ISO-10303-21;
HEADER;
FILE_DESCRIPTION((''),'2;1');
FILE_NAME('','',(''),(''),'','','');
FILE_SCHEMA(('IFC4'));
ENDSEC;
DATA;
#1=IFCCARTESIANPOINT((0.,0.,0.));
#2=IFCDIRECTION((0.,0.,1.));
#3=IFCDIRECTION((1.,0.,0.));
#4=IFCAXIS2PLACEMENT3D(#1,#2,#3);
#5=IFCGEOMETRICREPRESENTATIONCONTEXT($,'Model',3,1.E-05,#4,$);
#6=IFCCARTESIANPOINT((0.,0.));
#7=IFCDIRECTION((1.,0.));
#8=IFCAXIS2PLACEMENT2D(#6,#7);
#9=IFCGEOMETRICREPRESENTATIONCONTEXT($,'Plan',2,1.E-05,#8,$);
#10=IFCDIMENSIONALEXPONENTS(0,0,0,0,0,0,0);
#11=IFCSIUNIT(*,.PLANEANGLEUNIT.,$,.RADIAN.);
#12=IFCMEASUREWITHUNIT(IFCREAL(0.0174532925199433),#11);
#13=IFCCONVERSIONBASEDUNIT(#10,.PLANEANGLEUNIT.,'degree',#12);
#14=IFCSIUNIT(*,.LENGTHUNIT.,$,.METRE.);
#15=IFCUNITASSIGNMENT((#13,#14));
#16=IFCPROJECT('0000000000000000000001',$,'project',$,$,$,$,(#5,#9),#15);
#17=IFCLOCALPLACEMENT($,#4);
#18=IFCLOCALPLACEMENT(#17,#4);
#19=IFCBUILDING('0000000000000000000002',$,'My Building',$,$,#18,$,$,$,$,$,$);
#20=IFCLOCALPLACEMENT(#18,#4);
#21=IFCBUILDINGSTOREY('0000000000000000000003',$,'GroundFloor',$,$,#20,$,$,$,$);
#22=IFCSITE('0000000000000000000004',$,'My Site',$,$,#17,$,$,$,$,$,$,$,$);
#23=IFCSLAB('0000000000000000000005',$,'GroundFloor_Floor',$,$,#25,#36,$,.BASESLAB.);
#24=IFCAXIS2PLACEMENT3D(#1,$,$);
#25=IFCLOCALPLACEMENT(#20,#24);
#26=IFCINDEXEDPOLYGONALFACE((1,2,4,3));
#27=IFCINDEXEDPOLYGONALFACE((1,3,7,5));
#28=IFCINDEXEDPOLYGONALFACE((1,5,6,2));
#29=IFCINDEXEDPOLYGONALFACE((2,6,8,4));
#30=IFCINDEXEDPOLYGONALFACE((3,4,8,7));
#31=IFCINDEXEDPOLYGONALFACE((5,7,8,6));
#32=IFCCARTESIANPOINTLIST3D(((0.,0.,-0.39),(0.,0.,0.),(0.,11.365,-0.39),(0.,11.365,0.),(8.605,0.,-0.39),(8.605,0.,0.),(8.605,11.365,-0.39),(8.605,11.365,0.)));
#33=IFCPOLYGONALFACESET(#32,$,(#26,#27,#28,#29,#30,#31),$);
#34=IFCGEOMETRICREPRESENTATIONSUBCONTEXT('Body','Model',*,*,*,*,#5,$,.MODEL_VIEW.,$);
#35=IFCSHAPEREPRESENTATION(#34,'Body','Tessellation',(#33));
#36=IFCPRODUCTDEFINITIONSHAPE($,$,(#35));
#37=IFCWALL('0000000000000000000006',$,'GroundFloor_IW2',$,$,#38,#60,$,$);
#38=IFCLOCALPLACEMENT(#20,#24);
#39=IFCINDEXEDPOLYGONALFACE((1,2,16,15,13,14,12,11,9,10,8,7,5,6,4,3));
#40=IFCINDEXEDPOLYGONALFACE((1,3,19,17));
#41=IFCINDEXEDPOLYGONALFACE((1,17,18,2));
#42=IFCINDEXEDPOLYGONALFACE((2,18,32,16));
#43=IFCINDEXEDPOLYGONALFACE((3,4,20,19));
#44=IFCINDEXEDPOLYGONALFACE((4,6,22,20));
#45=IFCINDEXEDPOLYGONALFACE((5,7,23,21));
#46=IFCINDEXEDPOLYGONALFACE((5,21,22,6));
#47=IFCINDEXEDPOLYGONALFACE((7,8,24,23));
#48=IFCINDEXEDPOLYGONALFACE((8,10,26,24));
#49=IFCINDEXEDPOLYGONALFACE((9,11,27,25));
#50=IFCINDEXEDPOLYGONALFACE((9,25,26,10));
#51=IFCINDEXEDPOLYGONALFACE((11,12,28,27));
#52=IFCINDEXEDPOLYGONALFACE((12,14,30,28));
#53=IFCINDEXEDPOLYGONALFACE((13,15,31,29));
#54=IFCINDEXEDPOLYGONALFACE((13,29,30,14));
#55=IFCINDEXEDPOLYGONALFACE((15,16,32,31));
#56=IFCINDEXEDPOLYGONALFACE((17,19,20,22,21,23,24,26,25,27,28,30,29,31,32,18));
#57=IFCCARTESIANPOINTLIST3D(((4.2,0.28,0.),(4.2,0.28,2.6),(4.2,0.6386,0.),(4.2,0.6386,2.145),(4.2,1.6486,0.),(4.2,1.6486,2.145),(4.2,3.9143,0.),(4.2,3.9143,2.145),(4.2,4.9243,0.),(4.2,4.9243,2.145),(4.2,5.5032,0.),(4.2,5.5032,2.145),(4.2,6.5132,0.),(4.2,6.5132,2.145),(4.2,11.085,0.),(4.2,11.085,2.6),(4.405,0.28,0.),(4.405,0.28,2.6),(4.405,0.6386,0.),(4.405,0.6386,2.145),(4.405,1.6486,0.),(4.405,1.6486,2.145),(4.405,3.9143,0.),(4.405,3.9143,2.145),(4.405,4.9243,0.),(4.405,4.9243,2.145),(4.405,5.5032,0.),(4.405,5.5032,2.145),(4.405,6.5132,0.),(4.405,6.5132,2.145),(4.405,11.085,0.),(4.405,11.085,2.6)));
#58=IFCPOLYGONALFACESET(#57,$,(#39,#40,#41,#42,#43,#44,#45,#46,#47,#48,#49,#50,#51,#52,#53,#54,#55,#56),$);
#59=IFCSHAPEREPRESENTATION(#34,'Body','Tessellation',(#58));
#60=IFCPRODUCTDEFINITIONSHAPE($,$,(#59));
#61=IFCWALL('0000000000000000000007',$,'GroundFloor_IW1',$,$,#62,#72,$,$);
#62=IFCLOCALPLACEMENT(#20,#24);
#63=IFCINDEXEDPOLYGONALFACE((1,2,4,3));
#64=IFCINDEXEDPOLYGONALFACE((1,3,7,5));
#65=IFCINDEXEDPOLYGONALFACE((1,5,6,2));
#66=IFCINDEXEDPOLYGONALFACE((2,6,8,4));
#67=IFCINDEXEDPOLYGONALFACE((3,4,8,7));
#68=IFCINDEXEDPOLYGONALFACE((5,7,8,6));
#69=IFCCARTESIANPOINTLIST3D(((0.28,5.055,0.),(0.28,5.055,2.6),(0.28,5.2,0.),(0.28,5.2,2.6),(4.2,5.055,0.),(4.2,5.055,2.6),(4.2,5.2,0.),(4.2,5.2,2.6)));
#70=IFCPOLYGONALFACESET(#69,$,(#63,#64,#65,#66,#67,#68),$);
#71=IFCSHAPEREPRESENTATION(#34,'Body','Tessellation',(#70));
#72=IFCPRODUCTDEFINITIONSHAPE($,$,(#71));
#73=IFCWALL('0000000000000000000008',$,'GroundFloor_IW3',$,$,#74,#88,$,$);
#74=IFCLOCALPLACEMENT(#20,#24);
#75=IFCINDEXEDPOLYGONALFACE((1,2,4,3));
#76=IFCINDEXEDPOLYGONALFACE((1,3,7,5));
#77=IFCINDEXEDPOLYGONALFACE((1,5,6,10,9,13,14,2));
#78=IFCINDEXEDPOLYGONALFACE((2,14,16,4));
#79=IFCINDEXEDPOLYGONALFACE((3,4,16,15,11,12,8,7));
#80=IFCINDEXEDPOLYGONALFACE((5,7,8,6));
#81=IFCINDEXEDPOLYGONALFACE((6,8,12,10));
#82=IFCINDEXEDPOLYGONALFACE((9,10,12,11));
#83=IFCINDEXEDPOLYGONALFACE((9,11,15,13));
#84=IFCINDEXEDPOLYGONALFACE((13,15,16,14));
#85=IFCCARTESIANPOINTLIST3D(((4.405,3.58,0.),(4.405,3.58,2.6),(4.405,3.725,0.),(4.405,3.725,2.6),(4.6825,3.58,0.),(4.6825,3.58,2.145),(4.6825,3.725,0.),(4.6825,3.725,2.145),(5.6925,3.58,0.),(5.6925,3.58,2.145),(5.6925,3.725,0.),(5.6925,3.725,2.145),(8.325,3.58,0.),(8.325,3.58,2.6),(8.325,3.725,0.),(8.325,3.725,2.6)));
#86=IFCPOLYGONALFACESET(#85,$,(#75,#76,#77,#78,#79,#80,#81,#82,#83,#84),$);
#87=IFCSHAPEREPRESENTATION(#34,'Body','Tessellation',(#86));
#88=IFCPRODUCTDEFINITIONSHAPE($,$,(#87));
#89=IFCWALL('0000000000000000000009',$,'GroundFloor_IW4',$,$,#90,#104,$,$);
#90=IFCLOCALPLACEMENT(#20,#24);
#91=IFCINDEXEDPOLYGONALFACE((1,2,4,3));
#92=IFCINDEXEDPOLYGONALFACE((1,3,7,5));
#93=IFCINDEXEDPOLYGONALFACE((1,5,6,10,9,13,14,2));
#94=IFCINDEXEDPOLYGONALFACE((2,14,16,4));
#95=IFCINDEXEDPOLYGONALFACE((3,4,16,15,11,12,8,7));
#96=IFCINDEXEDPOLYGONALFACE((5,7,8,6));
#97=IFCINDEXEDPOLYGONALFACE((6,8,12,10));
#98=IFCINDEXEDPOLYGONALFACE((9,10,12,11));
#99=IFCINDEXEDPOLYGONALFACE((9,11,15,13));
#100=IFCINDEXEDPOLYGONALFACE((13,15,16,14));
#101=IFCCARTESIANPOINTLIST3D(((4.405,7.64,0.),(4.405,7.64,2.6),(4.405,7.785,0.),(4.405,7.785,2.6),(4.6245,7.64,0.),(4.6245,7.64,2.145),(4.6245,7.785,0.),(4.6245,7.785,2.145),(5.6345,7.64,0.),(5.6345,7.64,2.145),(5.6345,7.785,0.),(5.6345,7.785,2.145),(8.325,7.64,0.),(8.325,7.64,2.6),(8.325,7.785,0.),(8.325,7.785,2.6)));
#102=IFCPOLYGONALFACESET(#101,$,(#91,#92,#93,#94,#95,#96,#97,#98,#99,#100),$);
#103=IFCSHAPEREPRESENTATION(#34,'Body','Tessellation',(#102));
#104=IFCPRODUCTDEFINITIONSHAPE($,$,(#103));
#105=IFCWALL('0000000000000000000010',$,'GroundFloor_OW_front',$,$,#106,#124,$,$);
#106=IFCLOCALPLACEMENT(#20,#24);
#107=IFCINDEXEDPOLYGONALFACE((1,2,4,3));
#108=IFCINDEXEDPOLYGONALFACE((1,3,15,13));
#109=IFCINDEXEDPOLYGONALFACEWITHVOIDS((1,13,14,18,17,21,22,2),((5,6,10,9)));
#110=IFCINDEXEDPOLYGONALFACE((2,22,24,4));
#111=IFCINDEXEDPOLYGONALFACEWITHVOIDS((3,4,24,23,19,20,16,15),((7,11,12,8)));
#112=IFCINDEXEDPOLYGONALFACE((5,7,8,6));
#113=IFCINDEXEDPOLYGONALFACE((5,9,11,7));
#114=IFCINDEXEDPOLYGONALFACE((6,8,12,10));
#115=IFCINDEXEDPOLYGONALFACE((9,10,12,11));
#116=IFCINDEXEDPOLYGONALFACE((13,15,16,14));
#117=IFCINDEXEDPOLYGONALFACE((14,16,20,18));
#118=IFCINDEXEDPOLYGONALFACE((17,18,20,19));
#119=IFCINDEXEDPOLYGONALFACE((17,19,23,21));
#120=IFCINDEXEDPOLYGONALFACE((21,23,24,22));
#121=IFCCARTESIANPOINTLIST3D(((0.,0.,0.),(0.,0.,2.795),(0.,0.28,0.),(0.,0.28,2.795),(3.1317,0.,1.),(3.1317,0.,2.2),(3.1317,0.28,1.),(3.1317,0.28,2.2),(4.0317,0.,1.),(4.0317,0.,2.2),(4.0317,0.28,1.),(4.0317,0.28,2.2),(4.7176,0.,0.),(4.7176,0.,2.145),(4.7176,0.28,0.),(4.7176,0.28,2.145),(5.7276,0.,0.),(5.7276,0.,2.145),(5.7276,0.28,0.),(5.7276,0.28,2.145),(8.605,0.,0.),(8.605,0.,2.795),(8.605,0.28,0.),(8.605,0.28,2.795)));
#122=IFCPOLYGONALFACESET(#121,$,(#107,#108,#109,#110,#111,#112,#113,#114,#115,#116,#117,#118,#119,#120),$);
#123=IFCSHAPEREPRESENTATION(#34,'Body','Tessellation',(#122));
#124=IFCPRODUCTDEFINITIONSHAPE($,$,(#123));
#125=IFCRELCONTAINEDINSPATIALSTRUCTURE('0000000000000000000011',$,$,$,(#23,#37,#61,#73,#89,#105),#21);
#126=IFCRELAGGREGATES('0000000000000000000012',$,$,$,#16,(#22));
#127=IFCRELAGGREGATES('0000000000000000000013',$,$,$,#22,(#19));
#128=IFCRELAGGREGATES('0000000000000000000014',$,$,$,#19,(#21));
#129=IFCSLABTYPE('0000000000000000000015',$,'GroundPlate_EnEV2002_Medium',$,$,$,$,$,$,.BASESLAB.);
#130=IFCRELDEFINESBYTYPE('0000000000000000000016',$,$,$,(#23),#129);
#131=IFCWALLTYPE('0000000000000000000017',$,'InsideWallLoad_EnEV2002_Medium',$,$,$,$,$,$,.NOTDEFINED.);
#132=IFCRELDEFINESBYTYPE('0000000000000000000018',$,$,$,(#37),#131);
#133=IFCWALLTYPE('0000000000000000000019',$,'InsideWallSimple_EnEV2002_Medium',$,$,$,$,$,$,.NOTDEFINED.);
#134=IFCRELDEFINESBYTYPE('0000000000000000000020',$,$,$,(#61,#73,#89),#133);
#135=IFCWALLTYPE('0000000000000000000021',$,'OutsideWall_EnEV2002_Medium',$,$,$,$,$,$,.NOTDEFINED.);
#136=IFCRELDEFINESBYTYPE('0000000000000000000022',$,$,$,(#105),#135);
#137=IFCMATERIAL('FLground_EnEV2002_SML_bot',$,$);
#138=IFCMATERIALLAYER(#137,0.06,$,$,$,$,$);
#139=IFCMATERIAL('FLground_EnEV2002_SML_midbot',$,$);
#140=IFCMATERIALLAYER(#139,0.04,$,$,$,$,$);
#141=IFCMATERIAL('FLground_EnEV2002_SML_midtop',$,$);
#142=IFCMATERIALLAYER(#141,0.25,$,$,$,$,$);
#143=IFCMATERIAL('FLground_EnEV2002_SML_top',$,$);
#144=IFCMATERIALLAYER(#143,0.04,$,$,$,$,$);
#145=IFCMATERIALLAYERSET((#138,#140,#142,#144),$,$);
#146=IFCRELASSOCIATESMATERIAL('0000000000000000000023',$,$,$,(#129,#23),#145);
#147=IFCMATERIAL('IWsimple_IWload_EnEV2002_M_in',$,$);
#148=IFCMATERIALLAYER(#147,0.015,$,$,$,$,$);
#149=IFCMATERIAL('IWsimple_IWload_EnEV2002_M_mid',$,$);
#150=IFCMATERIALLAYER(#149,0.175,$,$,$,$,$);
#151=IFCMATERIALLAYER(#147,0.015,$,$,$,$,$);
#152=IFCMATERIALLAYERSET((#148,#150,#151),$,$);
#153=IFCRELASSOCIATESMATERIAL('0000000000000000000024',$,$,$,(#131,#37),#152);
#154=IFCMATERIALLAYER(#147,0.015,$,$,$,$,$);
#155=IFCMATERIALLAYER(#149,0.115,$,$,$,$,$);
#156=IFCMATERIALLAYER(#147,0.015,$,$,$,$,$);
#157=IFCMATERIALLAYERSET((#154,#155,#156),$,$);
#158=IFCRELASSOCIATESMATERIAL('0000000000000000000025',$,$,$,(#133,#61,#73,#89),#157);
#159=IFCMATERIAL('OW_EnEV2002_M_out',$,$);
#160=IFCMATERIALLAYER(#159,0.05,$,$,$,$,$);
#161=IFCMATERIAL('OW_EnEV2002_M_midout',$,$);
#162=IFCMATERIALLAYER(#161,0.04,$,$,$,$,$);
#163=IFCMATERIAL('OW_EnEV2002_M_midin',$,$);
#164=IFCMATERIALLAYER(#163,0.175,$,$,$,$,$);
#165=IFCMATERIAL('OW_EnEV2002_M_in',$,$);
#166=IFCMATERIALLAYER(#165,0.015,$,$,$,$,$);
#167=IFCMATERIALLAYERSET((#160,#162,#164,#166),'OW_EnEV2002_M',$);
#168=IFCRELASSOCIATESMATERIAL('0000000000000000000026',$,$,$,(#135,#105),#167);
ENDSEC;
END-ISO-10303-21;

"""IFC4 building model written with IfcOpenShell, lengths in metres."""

from ifc_helpers import new_model, entity, si_unit, converted_unit, frame, origin_with_axes, origin_2d_with_axis, place, context, subcontext, project, spatial, line, indexed_curve, outline, extrude, source, transform, mapped, material, layer, layer_set, layer_usage, type_object, element, save


model = new_model("IFC4")

# Units and contexts
model_context = context("Model", 3, precision=1e-05, world=origin_with_axes())
plan_context = context("Plan", 2, precision=1e-05, world=origin_2d_with_axis())
body_context = subcontext(model_context, "Body", "Model", "MODEL_VIEW")
ifc_project = project(units=[converted_unit("PLANEANGLEUNIT", "degree", entity("IfcReal", 0.0174532925199433), si_unit("PLANEANGLEUNIT", "RADIAN"), dimensions=[0, 0, 0, 0, 0, 0, 0]), si_unit("LENGTHUNIT", "METRE")], contexts=[model_context, plan_context])

# Site, building, storey
site_placement = place(None, origin_with_axes())
site = spatial("IfcSite", under=ifc_project, at=site_placement, Name="My Site")
building_placement = place(site_placement, origin_with_axes())
building = spatial("IfcBuilding", under=site, at=building_placement, Name="My Building")
storey_placement = place(building_placement, origin_with_axes())
storey = spatial("IfcBuildingStorey", under=building, at=storey_placement, Name="GroundFloor")

# Slab
ifc_material_1 = material(Name="FLground_EnEV2002_SML_bot")
ifc_layer_1 = layer(ifc_material_1, 0.06)
ifc_material_2 = material(Name="FLground_EnEV2002_SML_midbot")
ifc_layer_2 = layer(ifc_material_2, 0.04)
ifc_material_3 = material(Name="FLground_EnEV2002_SML_midtop")
ifc_layer_3 = layer(ifc_material_3, 0.25)
ifc_material_4 = material(Name="FLground_EnEV2002_SML_top")
ifc_layer_4 = layer(ifc_material_4, 0.04)
ifc_layer_set_1 = layer_set([ifc_layer_1, ifc_layer_2, ifc_layer_3, ifc_layer_4])
ifc_layer_usage_1 = layer_usage(ifc_layer_set_1, "AXIS3", "POSITIVE", 0.0)
slab_type = type_object("IfcSlabType", Name="GroundPlate_EnEV2002_Medium", PredefinedType="BASESLAB", material=ifc_layer_set_1)
slab_placement = place(storey_placement, frame((0.0, 0.0, -0.39), z_axis=(0.0, 0.0, 1.0), x_axis=(1.0, 0.0, 0.0)))
element("IfcSlab", 1, at=slab_placement, inside=storey, type_object=slab_type, material=ifc_layer_usage_1, Name="GroundFloor_Floor", PredefinedType="BASESLAB", context=body_context, shape_type="SweptSolid", body=[
    extrude(outline(indexed_curve([(0.0, 0.0), (8.605, 0.0), (8.605, 11.365), (0.0, 11.365)], segments=[line(4, 1), line(1, 2), line(2, 3), line(3, 4)], self_intersect=False)), None, (0.0, 0.0, 1.0), 0.39),
])

# Wall, openings
ifc_material_5 = material(Name="IWsimple_IWload_EnEV2002_M_in")
ifc_layer_5 = layer(ifc_material_5, 0.015)
ifc_material_6 = material(Name="IWsimple_IWload_EnEV2002_M_mid")
ifc_layer_6 = layer(ifc_material_6, 0.175)
ifc_layer_7 = layer(ifc_material_5, 0.015)
ifc_layer_set_2 = layer_set([ifc_layer_5, ifc_layer_6, ifc_layer_7])
ifc_layer_usage_2 = layer_usage(ifc_layer_set_2, "AXIS2", "POSITIVE", 0.0)
wall_type_1 = type_object("IfcWallType", Name="InsideWallLoad_EnEV2002_Medium", PredefinedType="NOTDEFINED", material=ifc_layer_set_2)
wall_1_placement = place(storey_placement, frame((4.405, 0.28, 0.0), z_axis=(0.0, 0.0, 1.0), x_axis=(0.0, 1.0, 0.0)))
wall_1 = element("IfcWall", 2, at=wall_1_placement, inside=storey, type_object=wall_type_1, material=ifc_layer_usage_2, Name="GroundFloor_IW2", context=body_context, shape_type="SweptSolid", body=[
    extrude(outline(indexed_curve([(0.0, 0.0), (0.0, 0.205), (10.805, 0.205), (10.805, 0.0), (0.0, 0.0)], self_intersect=False)), origin_with_axes(), (0.0, 0.0, 1.0), 2.6),
])
shared_shape_1 = source(origin_with_axes(), body_context, "Body", "SweptSolid", [
    extrude(outline(indexed_curve([(0.0, 0.0), (1.01, 0.0), (1.01, 2.145), (0.0, 2.145)], segments=[line(1, 2, 3, 4, 1)])), frame((0.0, -0.1, 0.0), z_axis=(0.0, -1.0, 0.0), x_axis=(1.0, 0.0, 0.0)), (0.0, 0.0, -1.0), 0.48),
])
opening_1_placement = place(wall_1_placement, frame((3.6343, 0.0, 0.0), z_axis=(0.0, 0.0, 1.0), x_axis=(1.0, 0.0, 0.0)))
element("IfcOpeningElement", 3, at=opening_1_placement, cuts=wall_1, PredefinedType="OPENING", context=body_context, shape_type="MappedRepresentation", body=[
    mapped(shared_shape_1, transform((0.0, 0.0, 0.0), x_axis=(1.0, 0.0, 0.0), y_axis=(0.0, 1.0, 0.0), z_axis=(0.0, 0.0, 1.0), scale=1.0)),
])
opening_2_placement = place(wall_1_placement, frame((5.2232, 0.0, 0.0), z_axis=(0.0, 0.0, 1.0), x_axis=(1.0, 0.0, 0.0)))
element("IfcOpeningElement", 4, at=opening_2_placement, cuts=wall_1, PredefinedType="OPENING", context=body_context, shape_type="MappedRepresentation", body=[
    mapped(shared_shape_1, transform((0.0, 0.0, 0.0), x_axis=(1.0, 0.0, 0.0), y_axis=(0.0, 1.0, 0.0), z_axis=(0.0, 0.0, 1.0), scale=1.0)),
])
opening_3_placement = place(wall_1_placement, frame((0.3586, 0.0, 0.0), z_axis=(0.0, 0.0, 1.0), x_axis=(1.0, 0.0, 0.0)))
element("IfcOpeningElement", 5, at=opening_3_placement, cuts=wall_1, PredefinedType="OPENING", context=body_context, shape_type="MappedRepresentation", body=[
    mapped(shared_shape_1, transform((0.0, 0.0, 0.0), x_axis=(1.0, 0.0, 0.0), y_axis=(0.0, 1.0, 0.0), z_axis=(0.0, 0.0, 1.0), scale=1.0)),
])

# Wall
ifc_layer_8 = layer(ifc_material_5, 0.015)
ifc_layer_9 = layer(ifc_material_6, 0.115)
ifc_layer_10 = layer(ifc_material_5, 0.015)
ifc_layer_set_3 = layer_set([ifc_layer_8, ifc_layer_9, ifc_layer_10])
ifc_layer_usage_3 = layer_usage(ifc_layer_set_3, "AXIS2", "POSITIVE", 0.0)
wall_type_2 = type_object("IfcWallType", Name="InsideWallSimple_EnEV2002_Medium", PredefinedType="NOTDEFINED", material=ifc_layer_set_3)
wall_2_placement = place(storey_placement, frame((0.28, 5.055, 0.0), z_axis=(0.0, 0.0, 1.0), x_axis=(1.0, 0.0, 0.0)))
element("IfcWall", 6, at=wall_2_placement, inside=storey, type_object=wall_type_2, material=ifc_layer_usage_3, Name="GroundFloor_IW1", context=body_context, shape_type="SweptSolid", body=[
    extrude(outline(indexed_curve([(0.0, 0.0), (0.0, 0.145), (3.92, 0.145), (3.92, 0.0), (0.0, 0.0)], self_intersect=False)), origin_with_axes(), (0.0, 0.0, 1.0), 2.6),
])

# Walls, openings
ifc_layer_usage_4 = layer_usage(ifc_layer_set_3, "AXIS2", "POSITIVE", 0.0)
wall_3_placement = place(storey_placement, frame((4.405, 3.58, 0.0), z_axis=(0.0, 0.0, 1.0), x_axis=(1.0, 0.0, 0.0)))
wall_3 = element("IfcWall", 7, at=wall_3_placement, inside=storey, type_object=wall_type_2, material=ifc_layer_usage_4, Name="GroundFloor_IW3", context=body_context, shape_type="SweptSolid", body=[
    extrude(outline(indexed_curve([(0.0, 0.0), (0.0, 0.145), (3.92, 0.145), (3.92, 0.0), (0.0, 0.0)], self_intersect=False)), origin_with_axes(), (0.0, 0.0, 1.0), 2.6),
])
opening_4_placement = place(wall_3_placement, frame((0.2775, 0.0, 0.0), z_axis=(0.0, 0.0, 1.0), x_axis=(1.0, 0.0, 0.0)))
element("IfcOpeningElement", 8, at=opening_4_placement, cuts=wall_3, PredefinedType="OPENING", context=body_context, shape_type="MappedRepresentation", body=[
    mapped(shared_shape_1, transform((0.0, 0.0, 0.0), x_axis=(1.0, 0.0, 0.0), y_axis=(0.0, 1.0, 0.0), z_axis=(0.0, 0.0, 1.0), scale=1.0)),
])
ifc_layer_usage_5 = layer_usage(ifc_layer_set_3, "AXIS2", "POSITIVE", 0.0)
wall_4_placement = place(storey_placement, frame((4.405, 7.64, 0.0), z_axis=(0.0, 0.0, 1.0), x_axis=(1.0, 0.0, 0.0)))
wall_4 = element("IfcWall", 9, at=wall_4_placement, inside=storey, type_object=wall_type_2, material=ifc_layer_usage_5, Name="GroundFloor_IW4", context=body_context, shape_type="SweptSolid", body=[
    extrude(outline(indexed_curve([(0.0, 0.0), (0.0, 0.145), (3.92, 0.145), (3.92, 0.0), (0.0, 0.0)], self_intersect=False)), origin_with_axes(), (0.0, 0.0, 1.0), 2.6),
])
opening_5_placement = place(wall_4_placement, frame((0.2195, 0.0, 0.0), z_axis=(0.0, 0.0, 1.0), x_axis=(1.0, 0.0, 0.0)))
element("IfcOpeningElement", 10, at=opening_5_placement, cuts=wall_4, PredefinedType="OPENING", context=body_context, shape_type="MappedRepresentation", body=[
    mapped(shared_shape_1, transform((0.0, 0.0, 0.0), x_axis=(1.0, 0.0, 0.0), y_axis=(0.0, 1.0, 0.0), z_axis=(0.0, 0.0, 1.0), scale=1.0)),
])

# Wall, openings
ifc_material_7 = material(Name="OW_EnEV2002_M_out")
ifc_layer_11 = layer(ifc_material_7, 0.05)
ifc_material_8 = material(Name="OW_EnEV2002_M_midout")
ifc_layer_12 = layer(ifc_material_8, 0.04)
ifc_material_9 = material(Name="OW_EnEV2002_M_midin")
ifc_layer_13 = layer(ifc_material_9, 0.175)
ifc_material_10 = material(Name="OW_EnEV2002_M_in")
ifc_layer_14 = layer(ifc_material_10, 0.015)
ifc_layer_set_4 = layer_set([ifc_layer_11, ifc_layer_12, ifc_layer_13, ifc_layer_14], Name="OW_EnEV2002_M")
ifc_layer_usage_6 = layer_usage(ifc_layer_set_4, "AXIS2", "POSITIVE", 0.0)
wall_type_3 = type_object("IfcWallType", Name="OutsideWall_EnEV2002_Medium", PredefinedType="NOTDEFINED", material=ifc_layer_set_4)
wall_5_placement = place(storey_placement, origin_with_axes())
wall_5 = element("IfcWall", 11, at=wall_5_placement, inside=storey, type_object=wall_type_3, material=ifc_layer_usage_6, Name="GroundFloor_OW_front", context=body_context, shape_type="SweptSolid", body=[
    extrude(outline(indexed_curve([(0.0, 0.0), (0.0, 0.28), (8.605, 0.28), (8.605, 0.0), (0.0, 0.0)], self_intersect=False)), origin_with_axes(), (0.0, 0.0, 1.0), 2.795),
])
opening_6_placement = place(wall_5_placement, frame((4.7176, 0.0, 0.0), z_axis=(0.0, 0.0, 1.0), x_axis=(1.0, 0.0, 0.0)))
element("IfcOpeningElement", 12, at=opening_6_placement, cuts=wall_5, PredefinedType="OPENING", context=body_context, shape_type="MappedRepresentation", body=[
    mapped(shared_shape_1, transform((0.0, 0.0, 0.0), x_axis=(1.0, 0.0, 0.0), y_axis=(0.0, 1.0, 0.0), z_axis=(0.0, 0.0, 1.0), scale=1.0)),
])
shared_shape_2 = source(origin_with_axes(), body_context, "Body", "SweptSolid", [
    extrude(outline(indexed_curve([(0.0, 0.0), (0.9, 0.0), (0.9, 1.2), (0.0, 1.2)], segments=[line(1, 2, 3, 4, 1)])), frame((0.0, -0.1, 0.0), z_axis=(0.0, -1.0, 0.0), x_axis=(1.0, 0.0, 0.0)), (0.0, 0.0, -1.0), 0.48),
])
opening_7_placement = place(wall_5_placement, frame((3.1317, 0.0, 1.0), z_axis=(0.0, 0.0, 1.0), x_axis=(1.0, 0.0, 0.0)))
element("IfcOpeningElement", 13, at=opening_7_placement, cuts=wall_5, PredefinedType="OPENING", context=body_context, shape_type="MappedRepresentation", body=[
    mapped(shared_shape_2, transform((0.0, 0.0, 0.0), x_axis=(1.0, 0.0, 0.0), y_axis=(0.0, 1.0, 0.0), z_axis=(0.0, 0.0, 1.0), scale=1.0)),
])

save(model, "model.ifc")
